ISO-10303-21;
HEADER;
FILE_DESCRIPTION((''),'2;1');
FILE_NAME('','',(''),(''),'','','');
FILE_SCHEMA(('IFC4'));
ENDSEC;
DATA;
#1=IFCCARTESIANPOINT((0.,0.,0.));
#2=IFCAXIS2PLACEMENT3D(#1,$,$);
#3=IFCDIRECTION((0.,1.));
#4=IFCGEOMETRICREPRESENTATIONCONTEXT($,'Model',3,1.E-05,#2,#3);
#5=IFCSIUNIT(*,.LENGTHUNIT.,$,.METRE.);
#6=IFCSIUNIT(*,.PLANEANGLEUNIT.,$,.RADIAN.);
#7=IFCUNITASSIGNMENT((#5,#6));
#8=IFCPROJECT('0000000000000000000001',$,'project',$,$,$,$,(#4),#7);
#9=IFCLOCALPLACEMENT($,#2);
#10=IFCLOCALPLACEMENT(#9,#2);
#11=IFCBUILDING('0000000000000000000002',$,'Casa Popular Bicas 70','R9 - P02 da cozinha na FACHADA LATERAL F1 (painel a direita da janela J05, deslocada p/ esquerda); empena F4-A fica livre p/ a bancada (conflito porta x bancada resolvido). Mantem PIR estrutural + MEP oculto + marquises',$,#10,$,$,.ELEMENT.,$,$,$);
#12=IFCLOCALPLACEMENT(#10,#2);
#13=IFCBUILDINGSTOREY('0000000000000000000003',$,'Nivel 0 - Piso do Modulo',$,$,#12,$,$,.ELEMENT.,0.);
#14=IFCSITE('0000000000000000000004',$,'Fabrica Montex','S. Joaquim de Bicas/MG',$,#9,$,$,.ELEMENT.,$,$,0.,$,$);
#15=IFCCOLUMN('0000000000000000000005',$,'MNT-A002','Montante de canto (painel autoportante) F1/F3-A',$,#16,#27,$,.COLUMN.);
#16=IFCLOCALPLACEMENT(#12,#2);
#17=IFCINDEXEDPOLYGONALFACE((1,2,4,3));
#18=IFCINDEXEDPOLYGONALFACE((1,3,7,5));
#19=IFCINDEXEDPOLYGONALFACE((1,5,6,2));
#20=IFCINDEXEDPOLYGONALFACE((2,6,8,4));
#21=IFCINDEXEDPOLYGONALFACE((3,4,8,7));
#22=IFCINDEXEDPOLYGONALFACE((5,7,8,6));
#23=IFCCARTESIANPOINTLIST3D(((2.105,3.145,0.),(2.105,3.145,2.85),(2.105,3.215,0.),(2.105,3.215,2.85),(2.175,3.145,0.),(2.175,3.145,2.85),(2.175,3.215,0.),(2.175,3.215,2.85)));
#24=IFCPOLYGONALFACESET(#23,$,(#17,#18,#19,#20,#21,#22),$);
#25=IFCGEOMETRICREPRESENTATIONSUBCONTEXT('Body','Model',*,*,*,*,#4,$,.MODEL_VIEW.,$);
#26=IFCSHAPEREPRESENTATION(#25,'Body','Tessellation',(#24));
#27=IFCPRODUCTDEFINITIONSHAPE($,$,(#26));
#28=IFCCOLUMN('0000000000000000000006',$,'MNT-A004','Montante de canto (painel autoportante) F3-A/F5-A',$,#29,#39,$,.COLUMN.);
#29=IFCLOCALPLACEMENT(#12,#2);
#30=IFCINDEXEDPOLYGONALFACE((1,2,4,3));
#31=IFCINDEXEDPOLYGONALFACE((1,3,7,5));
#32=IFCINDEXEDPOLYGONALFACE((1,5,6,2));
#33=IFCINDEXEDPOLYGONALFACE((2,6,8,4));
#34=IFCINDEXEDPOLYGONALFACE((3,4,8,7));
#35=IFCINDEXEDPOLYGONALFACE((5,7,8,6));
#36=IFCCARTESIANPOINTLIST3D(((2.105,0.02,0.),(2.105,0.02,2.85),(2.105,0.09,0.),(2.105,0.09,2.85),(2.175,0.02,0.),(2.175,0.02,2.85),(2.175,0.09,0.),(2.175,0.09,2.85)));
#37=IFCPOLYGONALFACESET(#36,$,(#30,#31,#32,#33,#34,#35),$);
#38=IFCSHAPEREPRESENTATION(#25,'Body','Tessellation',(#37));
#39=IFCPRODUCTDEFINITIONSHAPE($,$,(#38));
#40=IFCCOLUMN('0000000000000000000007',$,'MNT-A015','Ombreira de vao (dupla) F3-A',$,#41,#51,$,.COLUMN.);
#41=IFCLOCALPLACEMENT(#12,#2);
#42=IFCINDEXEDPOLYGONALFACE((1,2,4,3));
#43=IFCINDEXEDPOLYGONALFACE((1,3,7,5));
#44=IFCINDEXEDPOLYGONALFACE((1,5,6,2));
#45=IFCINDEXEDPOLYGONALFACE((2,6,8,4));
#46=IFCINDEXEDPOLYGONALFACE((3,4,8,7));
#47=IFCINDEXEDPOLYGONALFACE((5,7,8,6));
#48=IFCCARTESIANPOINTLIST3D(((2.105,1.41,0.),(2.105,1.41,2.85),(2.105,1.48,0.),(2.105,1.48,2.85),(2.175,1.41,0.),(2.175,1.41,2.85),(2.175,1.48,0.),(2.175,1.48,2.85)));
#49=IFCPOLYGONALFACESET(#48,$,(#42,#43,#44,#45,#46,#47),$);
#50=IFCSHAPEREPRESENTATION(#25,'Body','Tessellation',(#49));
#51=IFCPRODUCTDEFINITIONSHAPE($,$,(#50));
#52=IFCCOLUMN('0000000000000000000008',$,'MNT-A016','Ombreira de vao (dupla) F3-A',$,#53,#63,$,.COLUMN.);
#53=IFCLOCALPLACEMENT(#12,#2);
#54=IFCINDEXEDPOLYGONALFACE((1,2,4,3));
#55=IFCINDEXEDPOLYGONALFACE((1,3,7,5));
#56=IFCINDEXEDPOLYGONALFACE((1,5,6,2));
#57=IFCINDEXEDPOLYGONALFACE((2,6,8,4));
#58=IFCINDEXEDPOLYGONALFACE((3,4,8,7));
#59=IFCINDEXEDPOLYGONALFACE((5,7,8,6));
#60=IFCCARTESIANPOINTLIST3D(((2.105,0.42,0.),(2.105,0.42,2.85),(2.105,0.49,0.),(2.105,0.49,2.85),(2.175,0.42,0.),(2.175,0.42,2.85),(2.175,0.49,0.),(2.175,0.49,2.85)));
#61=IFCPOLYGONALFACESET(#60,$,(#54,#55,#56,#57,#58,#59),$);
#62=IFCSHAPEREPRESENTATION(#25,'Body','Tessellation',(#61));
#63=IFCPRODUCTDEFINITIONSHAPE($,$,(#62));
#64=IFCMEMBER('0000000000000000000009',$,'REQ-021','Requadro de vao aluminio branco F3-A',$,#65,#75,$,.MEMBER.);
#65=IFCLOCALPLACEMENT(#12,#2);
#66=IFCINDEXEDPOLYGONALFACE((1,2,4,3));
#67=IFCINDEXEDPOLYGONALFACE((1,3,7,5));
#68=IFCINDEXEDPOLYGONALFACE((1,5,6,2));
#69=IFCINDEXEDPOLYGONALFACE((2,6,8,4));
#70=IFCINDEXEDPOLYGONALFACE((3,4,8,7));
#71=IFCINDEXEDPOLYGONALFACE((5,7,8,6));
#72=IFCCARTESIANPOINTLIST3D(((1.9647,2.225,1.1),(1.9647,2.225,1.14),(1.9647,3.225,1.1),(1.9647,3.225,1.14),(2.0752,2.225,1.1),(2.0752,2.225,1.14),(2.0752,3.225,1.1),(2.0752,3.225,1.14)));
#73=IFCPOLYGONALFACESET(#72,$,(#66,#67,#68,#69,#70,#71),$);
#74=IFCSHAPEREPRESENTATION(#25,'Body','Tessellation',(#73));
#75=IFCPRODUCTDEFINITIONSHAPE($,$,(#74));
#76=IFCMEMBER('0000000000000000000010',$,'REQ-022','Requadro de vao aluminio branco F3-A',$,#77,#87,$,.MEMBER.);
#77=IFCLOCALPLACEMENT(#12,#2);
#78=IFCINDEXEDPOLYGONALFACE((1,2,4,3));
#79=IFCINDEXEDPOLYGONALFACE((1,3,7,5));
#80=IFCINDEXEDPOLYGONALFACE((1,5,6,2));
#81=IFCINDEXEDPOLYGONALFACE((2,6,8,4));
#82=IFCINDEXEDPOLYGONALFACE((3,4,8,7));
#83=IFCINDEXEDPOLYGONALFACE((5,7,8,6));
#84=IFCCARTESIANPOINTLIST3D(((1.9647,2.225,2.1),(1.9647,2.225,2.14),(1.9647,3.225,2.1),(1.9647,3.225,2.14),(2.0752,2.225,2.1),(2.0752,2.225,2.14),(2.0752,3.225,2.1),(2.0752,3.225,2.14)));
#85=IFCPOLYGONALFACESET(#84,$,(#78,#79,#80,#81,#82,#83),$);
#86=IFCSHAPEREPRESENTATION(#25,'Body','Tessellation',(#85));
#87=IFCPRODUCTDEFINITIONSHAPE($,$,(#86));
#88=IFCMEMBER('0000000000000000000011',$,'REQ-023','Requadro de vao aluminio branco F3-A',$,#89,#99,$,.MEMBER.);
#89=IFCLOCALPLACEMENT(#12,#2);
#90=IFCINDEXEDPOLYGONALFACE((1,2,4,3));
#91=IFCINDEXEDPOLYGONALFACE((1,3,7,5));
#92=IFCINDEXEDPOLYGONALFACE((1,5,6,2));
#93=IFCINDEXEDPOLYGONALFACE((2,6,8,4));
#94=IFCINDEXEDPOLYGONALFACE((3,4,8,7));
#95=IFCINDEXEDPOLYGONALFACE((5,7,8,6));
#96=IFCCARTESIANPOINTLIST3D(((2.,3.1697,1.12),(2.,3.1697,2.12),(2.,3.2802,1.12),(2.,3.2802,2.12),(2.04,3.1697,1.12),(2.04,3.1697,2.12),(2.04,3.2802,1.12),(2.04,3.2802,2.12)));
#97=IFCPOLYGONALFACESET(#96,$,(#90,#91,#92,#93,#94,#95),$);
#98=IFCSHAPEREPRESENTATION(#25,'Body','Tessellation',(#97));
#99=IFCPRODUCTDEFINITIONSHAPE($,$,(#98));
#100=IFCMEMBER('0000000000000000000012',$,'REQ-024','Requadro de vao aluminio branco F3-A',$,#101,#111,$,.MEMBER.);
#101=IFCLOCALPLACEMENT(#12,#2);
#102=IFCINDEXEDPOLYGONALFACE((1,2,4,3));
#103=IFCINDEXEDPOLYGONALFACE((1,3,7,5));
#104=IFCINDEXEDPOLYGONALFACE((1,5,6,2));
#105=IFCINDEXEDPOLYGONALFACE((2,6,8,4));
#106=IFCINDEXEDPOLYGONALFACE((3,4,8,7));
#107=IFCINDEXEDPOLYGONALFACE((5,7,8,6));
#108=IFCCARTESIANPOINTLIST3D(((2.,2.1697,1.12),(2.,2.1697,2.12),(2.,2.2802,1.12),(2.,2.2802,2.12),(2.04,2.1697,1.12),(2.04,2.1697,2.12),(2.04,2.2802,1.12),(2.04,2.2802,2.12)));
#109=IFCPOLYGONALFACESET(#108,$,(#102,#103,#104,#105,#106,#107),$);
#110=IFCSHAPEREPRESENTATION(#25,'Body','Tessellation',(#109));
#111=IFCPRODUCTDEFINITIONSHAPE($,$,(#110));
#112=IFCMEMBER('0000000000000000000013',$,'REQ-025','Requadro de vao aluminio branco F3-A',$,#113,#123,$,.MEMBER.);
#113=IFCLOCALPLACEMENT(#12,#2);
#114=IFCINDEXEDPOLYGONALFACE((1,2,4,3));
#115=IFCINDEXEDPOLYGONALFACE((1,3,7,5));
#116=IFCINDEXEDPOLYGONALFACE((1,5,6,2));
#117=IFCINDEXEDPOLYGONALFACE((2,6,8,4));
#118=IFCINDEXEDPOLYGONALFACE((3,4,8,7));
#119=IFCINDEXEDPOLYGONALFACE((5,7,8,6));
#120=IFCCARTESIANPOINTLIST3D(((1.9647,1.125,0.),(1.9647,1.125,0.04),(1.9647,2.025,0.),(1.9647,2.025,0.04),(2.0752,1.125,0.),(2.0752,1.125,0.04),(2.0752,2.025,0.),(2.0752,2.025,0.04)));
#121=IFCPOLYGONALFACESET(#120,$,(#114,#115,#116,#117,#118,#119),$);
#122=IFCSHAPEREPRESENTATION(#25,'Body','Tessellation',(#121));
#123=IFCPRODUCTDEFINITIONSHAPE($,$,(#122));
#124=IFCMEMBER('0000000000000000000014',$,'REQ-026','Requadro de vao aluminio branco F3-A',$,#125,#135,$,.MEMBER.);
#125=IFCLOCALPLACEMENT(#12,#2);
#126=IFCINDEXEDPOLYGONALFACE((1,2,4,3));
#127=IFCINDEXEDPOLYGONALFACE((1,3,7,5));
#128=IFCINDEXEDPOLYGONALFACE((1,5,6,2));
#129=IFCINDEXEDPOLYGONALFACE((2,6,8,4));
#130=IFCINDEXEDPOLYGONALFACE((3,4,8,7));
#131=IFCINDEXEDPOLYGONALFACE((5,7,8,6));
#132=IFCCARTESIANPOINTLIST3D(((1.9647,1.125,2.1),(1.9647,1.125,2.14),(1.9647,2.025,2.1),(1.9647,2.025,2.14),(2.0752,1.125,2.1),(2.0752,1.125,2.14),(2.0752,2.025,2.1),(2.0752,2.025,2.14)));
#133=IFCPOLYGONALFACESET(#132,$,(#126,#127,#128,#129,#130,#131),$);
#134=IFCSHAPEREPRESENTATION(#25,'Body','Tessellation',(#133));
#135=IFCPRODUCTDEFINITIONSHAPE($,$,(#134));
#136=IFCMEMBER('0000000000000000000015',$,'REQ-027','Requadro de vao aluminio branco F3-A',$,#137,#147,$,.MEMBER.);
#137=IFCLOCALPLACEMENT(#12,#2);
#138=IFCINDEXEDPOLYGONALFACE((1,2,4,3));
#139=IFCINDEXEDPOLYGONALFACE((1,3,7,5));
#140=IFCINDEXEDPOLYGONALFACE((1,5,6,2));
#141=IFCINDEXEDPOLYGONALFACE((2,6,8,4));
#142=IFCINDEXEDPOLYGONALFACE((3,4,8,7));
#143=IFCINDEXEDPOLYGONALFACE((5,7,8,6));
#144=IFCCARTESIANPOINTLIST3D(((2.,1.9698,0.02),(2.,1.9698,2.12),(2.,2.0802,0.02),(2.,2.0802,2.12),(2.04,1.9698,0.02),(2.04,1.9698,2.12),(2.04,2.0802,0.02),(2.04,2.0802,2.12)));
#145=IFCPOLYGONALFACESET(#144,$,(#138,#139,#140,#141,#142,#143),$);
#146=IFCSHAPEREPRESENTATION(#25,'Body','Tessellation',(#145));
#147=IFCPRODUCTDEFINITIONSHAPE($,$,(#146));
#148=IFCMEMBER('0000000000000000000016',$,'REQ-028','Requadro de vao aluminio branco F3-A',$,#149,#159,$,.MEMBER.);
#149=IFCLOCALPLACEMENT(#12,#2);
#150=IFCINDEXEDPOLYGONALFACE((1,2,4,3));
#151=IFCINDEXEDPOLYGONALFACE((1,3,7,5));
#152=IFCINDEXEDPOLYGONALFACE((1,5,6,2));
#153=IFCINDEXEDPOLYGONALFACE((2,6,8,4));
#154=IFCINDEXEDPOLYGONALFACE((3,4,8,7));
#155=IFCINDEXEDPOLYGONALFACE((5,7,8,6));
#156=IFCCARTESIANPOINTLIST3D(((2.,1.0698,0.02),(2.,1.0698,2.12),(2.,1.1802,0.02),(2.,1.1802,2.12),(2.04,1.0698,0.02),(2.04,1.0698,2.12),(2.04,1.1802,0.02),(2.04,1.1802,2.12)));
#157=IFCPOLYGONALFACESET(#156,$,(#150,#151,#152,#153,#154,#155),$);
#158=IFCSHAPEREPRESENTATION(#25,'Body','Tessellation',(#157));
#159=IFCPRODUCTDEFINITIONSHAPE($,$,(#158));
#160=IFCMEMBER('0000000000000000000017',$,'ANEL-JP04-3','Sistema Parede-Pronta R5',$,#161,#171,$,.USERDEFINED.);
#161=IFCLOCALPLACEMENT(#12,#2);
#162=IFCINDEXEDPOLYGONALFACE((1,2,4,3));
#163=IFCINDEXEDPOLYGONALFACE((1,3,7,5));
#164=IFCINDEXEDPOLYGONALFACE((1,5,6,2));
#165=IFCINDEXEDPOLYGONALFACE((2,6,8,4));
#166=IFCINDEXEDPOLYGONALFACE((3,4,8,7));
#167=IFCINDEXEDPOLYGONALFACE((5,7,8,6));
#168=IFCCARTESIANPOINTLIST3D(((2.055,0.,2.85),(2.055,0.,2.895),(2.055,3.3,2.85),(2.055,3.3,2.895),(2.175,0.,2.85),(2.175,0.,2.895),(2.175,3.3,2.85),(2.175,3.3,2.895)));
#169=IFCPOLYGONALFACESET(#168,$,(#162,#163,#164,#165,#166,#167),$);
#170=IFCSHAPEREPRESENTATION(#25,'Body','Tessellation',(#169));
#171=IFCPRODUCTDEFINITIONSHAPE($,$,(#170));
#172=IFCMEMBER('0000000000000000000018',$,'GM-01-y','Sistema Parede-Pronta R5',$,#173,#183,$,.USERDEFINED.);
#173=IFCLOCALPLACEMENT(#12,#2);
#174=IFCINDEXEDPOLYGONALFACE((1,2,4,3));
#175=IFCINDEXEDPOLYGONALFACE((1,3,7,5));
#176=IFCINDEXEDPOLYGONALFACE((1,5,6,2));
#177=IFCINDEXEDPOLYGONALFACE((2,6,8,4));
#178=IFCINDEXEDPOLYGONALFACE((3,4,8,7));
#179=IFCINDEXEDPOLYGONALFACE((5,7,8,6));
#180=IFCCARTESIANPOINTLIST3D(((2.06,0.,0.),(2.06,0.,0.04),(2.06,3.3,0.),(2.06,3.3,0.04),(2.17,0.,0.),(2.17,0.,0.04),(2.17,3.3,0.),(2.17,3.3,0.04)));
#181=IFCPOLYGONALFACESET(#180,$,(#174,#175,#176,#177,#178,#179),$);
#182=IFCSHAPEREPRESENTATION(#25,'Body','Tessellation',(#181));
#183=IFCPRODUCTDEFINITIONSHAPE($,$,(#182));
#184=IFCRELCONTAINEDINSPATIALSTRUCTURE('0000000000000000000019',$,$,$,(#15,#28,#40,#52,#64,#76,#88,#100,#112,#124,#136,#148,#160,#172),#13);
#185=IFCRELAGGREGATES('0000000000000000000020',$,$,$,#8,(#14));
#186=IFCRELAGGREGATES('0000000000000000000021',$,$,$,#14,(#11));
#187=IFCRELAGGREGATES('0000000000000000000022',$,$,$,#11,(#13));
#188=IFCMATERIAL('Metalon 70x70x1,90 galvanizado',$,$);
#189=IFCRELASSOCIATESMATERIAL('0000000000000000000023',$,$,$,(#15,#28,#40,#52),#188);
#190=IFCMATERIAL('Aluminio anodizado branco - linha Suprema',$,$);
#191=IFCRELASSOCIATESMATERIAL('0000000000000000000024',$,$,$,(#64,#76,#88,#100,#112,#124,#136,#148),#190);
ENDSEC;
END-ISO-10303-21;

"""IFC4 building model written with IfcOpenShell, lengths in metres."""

from ifc_helpers import new_model, si_unit, direction, frame, origin, origin_2d, place, context, subcontext, project, spatial, rectangle, extrude, material, element, save


model = new_model("IFC4")

# Units and contexts
model_context = context("Model", 3, precision=1e-05, world=origin(), true_north=direction((0.0, 1.0)))
body_context = subcontext(model_context, "Body", "Model", "MODEL_VIEW")
ifc_project = project(units=[si_unit("LENGTHUNIT", "METRE"), si_unit("PLANEANGLEUNIT", "RADIAN")], contexts=[model_context])

# Site, building, storey
site_placement = place(None, origin())
site = spatial("IfcSite", under=ifc_project, at=site_placement, Name="Fabrica Montex", Description="S. Joaquim de Bicas/MG", CompositionType="ELEMENT", RefElevation=0.0)
building_placement = place(site_placement, origin())
building = spatial("IfcBuilding", under=site, at=building_placement, Name="Casa Popular Bicas 70", Description="R9 - P02 da cozinha na FACHADA LATERAL F1 (painel a direita da janela J05, deslocada p/ esquerda); empena F4-A fica livre p/ a bancada (conflito porta x bancada resolvido). Mantem PIR estrutural + MEP oculto + marquises", CompositionType="ELEMENT")
storey_placement = place(building_placement, origin())
storey = spatial("IfcBuildingStorey", under=building, at=storey_placement, Name="Nivel 0 - Piso do Modulo", CompositionType="ELEMENT", Elevation=0.0)

# Columns
ifc_material_1 = material(Name="Metalon 70x70x1,90 galvanizado")
for number, where, z_axis, x_axis, name, description in (
    (1, (2.14, 3.18, 0.0), (0.0, 0.0, 1.0), (-1.0, 0.0, 0.0), "MNT-A002", "Montante de canto (painel autoportante) F1/F3-A"),
    (2, (2.14, 0.055, 0.0), (0.0, 0.0, 1.0), (-1.0, 0.0, 0.0), "MNT-A004", "Montante de canto (painel autoportante) F3-A/F5-A"),
    (3, (2.14, 1.445, 0.0), (0.0, 0.0, 1.0), (-1.0, 0.0, 0.0), "MNT-A015", "Ombreira de vao (dupla) F3-A"),
    (4, (2.14, 0.455, 0.0), (0.0, 0.0, 1.0), (-1.0, 0.0, 0.0), "MNT-A016", "Ombreira de vao (dupla) F3-A"),
):
    element("IfcColumn", number, at=place(None, frame(where, z_axis=z_axis, x_axis=x_axis)), inside=storey, material=ifc_material_1, Name=name, Description=description, PredefinedType="COLUMN", context=body_context, shape_type="SweptSolid", body=[
        extrude(rectangle(XDim=0.07, YDim=0.07, at=origin_2d()), origin(), (0.0, 0.0, 1.0), 2.85),
    ])

# Members
ifc_material_2 = material(Name="Aluminio anodizado branco - linha Suprema")
for number, where, z_axis, x_axis, name in (
    (5, (2.02, 3.225, 1.12), (0.0, -1.0, 0.0), (0.0, 0.0, 1.0), "REQ-021"),
    (6, (2.02, 3.225, 2.12), (0.0, -1.0, 0.0), (0.0, 0.0, 1.0), "REQ-022"),
    (7, (2.02, 3.225, 1.12), (0.0, 0.0, 1.0), (-1.0, 0.0, 0.0), "REQ-023"),
    (8, (2.02, 2.225, 1.12), (0.0, 0.0, 1.0), (-1.0, 0.0, 0.0), "REQ-024"),
):
    element("IfcMember", number, at=place(None, frame(where, z_axis=z_axis, x_axis=x_axis)), inside=storey, material=ifc_material_2, Name=name, Description="Requadro de vao aluminio branco F3-A", PredefinedType="MEMBER", context=body_context, shape_type="SweptSolid", body=[
        extrude(rectangle(XDim=0.04, YDim=0.1105, at=origin_2d()), origin(), (0.0, 0.0, 1.0), 1.0),
    ])
for number, where, z_axis, x_axis, name in (
    (9, (2.02, 2.025, 0.02), (0.0, -1.0, 0.0), (0.0, 0.0, 1.0), "REQ-025"),
    (10, (2.02, 2.025, 2.12), (0.0, -1.0, 0.0), (0.0, 0.0, 1.0), "REQ-026"),
):
    element("IfcMember", number, at=place(None, frame(where, z_axis=z_axis, x_axis=x_axis)), inside=storey, material=ifc_material_2, Name=name, Description="Requadro de vao aluminio branco F3-A", PredefinedType="MEMBER", context=body_context, shape_type="SweptSolid", body=[
        extrude(rectangle(XDim=0.04, YDim=0.1105, at=origin_2d()), origin(), (0.0, 0.0, 1.0), 0.9),
    ])
for number, where, z_axis, x_axis, name in (
    (11, (2.02, 2.025, 0.02), (0.0, 0.0, 1.0), (-1.0, 0.0, 0.0), "REQ-027"),
    (12, (2.02, 1.125, 0.02), (0.0, 0.0, 1.0), (-1.0, 0.0, 0.0), "REQ-028"),
):
    element("IfcMember", number, at=place(None, frame(where, z_axis=z_axis, x_axis=x_axis)), inside=storey, material=ifc_material_2, Name=name, Description="Requadro de vao aluminio branco F3-A", PredefinedType="MEMBER", context=body_context, shape_type="SweptSolid", body=[
        extrude(rectangle(XDim=0.04, YDim=0.1105, at=origin_2d()), origin(), (0.0, 0.0, 1.0), 2.1),
    ])
member_1_placement = place(storey_placement, frame((2.115, 1.65, 2.85)))
element("IfcMember", 13, at=member_1_placement, inside=storey, Name="ANEL-JP04-3", Description="Sistema Parede-Pronta R5", PredefinedType="USERDEFINED", context=body_context, shape_type="SweptSolid", body=[
    extrude(rectangle(XDim=0.12, YDim=3.3, at=origin_2d()), origin(), (0.0, 0.0, 1.0), 0.045),
])
member_2_placement = place(storey_placement, frame((2.115, 1.65, 0.0)))
element("IfcMember", 14, at=member_2_placement, inside=storey, Name="GM-01-y", Description="Sistema Parede-Pronta R5", PredefinedType="USERDEFINED", context=body_context, shape_type="SweptSolid", body=[
    extrude(rectangle(XDim=0.11, YDim=3.3, at=origin_2d()), origin(), (0.0, 0.0, 1.0), 0.04),
])

save(model, "model.ifc")
